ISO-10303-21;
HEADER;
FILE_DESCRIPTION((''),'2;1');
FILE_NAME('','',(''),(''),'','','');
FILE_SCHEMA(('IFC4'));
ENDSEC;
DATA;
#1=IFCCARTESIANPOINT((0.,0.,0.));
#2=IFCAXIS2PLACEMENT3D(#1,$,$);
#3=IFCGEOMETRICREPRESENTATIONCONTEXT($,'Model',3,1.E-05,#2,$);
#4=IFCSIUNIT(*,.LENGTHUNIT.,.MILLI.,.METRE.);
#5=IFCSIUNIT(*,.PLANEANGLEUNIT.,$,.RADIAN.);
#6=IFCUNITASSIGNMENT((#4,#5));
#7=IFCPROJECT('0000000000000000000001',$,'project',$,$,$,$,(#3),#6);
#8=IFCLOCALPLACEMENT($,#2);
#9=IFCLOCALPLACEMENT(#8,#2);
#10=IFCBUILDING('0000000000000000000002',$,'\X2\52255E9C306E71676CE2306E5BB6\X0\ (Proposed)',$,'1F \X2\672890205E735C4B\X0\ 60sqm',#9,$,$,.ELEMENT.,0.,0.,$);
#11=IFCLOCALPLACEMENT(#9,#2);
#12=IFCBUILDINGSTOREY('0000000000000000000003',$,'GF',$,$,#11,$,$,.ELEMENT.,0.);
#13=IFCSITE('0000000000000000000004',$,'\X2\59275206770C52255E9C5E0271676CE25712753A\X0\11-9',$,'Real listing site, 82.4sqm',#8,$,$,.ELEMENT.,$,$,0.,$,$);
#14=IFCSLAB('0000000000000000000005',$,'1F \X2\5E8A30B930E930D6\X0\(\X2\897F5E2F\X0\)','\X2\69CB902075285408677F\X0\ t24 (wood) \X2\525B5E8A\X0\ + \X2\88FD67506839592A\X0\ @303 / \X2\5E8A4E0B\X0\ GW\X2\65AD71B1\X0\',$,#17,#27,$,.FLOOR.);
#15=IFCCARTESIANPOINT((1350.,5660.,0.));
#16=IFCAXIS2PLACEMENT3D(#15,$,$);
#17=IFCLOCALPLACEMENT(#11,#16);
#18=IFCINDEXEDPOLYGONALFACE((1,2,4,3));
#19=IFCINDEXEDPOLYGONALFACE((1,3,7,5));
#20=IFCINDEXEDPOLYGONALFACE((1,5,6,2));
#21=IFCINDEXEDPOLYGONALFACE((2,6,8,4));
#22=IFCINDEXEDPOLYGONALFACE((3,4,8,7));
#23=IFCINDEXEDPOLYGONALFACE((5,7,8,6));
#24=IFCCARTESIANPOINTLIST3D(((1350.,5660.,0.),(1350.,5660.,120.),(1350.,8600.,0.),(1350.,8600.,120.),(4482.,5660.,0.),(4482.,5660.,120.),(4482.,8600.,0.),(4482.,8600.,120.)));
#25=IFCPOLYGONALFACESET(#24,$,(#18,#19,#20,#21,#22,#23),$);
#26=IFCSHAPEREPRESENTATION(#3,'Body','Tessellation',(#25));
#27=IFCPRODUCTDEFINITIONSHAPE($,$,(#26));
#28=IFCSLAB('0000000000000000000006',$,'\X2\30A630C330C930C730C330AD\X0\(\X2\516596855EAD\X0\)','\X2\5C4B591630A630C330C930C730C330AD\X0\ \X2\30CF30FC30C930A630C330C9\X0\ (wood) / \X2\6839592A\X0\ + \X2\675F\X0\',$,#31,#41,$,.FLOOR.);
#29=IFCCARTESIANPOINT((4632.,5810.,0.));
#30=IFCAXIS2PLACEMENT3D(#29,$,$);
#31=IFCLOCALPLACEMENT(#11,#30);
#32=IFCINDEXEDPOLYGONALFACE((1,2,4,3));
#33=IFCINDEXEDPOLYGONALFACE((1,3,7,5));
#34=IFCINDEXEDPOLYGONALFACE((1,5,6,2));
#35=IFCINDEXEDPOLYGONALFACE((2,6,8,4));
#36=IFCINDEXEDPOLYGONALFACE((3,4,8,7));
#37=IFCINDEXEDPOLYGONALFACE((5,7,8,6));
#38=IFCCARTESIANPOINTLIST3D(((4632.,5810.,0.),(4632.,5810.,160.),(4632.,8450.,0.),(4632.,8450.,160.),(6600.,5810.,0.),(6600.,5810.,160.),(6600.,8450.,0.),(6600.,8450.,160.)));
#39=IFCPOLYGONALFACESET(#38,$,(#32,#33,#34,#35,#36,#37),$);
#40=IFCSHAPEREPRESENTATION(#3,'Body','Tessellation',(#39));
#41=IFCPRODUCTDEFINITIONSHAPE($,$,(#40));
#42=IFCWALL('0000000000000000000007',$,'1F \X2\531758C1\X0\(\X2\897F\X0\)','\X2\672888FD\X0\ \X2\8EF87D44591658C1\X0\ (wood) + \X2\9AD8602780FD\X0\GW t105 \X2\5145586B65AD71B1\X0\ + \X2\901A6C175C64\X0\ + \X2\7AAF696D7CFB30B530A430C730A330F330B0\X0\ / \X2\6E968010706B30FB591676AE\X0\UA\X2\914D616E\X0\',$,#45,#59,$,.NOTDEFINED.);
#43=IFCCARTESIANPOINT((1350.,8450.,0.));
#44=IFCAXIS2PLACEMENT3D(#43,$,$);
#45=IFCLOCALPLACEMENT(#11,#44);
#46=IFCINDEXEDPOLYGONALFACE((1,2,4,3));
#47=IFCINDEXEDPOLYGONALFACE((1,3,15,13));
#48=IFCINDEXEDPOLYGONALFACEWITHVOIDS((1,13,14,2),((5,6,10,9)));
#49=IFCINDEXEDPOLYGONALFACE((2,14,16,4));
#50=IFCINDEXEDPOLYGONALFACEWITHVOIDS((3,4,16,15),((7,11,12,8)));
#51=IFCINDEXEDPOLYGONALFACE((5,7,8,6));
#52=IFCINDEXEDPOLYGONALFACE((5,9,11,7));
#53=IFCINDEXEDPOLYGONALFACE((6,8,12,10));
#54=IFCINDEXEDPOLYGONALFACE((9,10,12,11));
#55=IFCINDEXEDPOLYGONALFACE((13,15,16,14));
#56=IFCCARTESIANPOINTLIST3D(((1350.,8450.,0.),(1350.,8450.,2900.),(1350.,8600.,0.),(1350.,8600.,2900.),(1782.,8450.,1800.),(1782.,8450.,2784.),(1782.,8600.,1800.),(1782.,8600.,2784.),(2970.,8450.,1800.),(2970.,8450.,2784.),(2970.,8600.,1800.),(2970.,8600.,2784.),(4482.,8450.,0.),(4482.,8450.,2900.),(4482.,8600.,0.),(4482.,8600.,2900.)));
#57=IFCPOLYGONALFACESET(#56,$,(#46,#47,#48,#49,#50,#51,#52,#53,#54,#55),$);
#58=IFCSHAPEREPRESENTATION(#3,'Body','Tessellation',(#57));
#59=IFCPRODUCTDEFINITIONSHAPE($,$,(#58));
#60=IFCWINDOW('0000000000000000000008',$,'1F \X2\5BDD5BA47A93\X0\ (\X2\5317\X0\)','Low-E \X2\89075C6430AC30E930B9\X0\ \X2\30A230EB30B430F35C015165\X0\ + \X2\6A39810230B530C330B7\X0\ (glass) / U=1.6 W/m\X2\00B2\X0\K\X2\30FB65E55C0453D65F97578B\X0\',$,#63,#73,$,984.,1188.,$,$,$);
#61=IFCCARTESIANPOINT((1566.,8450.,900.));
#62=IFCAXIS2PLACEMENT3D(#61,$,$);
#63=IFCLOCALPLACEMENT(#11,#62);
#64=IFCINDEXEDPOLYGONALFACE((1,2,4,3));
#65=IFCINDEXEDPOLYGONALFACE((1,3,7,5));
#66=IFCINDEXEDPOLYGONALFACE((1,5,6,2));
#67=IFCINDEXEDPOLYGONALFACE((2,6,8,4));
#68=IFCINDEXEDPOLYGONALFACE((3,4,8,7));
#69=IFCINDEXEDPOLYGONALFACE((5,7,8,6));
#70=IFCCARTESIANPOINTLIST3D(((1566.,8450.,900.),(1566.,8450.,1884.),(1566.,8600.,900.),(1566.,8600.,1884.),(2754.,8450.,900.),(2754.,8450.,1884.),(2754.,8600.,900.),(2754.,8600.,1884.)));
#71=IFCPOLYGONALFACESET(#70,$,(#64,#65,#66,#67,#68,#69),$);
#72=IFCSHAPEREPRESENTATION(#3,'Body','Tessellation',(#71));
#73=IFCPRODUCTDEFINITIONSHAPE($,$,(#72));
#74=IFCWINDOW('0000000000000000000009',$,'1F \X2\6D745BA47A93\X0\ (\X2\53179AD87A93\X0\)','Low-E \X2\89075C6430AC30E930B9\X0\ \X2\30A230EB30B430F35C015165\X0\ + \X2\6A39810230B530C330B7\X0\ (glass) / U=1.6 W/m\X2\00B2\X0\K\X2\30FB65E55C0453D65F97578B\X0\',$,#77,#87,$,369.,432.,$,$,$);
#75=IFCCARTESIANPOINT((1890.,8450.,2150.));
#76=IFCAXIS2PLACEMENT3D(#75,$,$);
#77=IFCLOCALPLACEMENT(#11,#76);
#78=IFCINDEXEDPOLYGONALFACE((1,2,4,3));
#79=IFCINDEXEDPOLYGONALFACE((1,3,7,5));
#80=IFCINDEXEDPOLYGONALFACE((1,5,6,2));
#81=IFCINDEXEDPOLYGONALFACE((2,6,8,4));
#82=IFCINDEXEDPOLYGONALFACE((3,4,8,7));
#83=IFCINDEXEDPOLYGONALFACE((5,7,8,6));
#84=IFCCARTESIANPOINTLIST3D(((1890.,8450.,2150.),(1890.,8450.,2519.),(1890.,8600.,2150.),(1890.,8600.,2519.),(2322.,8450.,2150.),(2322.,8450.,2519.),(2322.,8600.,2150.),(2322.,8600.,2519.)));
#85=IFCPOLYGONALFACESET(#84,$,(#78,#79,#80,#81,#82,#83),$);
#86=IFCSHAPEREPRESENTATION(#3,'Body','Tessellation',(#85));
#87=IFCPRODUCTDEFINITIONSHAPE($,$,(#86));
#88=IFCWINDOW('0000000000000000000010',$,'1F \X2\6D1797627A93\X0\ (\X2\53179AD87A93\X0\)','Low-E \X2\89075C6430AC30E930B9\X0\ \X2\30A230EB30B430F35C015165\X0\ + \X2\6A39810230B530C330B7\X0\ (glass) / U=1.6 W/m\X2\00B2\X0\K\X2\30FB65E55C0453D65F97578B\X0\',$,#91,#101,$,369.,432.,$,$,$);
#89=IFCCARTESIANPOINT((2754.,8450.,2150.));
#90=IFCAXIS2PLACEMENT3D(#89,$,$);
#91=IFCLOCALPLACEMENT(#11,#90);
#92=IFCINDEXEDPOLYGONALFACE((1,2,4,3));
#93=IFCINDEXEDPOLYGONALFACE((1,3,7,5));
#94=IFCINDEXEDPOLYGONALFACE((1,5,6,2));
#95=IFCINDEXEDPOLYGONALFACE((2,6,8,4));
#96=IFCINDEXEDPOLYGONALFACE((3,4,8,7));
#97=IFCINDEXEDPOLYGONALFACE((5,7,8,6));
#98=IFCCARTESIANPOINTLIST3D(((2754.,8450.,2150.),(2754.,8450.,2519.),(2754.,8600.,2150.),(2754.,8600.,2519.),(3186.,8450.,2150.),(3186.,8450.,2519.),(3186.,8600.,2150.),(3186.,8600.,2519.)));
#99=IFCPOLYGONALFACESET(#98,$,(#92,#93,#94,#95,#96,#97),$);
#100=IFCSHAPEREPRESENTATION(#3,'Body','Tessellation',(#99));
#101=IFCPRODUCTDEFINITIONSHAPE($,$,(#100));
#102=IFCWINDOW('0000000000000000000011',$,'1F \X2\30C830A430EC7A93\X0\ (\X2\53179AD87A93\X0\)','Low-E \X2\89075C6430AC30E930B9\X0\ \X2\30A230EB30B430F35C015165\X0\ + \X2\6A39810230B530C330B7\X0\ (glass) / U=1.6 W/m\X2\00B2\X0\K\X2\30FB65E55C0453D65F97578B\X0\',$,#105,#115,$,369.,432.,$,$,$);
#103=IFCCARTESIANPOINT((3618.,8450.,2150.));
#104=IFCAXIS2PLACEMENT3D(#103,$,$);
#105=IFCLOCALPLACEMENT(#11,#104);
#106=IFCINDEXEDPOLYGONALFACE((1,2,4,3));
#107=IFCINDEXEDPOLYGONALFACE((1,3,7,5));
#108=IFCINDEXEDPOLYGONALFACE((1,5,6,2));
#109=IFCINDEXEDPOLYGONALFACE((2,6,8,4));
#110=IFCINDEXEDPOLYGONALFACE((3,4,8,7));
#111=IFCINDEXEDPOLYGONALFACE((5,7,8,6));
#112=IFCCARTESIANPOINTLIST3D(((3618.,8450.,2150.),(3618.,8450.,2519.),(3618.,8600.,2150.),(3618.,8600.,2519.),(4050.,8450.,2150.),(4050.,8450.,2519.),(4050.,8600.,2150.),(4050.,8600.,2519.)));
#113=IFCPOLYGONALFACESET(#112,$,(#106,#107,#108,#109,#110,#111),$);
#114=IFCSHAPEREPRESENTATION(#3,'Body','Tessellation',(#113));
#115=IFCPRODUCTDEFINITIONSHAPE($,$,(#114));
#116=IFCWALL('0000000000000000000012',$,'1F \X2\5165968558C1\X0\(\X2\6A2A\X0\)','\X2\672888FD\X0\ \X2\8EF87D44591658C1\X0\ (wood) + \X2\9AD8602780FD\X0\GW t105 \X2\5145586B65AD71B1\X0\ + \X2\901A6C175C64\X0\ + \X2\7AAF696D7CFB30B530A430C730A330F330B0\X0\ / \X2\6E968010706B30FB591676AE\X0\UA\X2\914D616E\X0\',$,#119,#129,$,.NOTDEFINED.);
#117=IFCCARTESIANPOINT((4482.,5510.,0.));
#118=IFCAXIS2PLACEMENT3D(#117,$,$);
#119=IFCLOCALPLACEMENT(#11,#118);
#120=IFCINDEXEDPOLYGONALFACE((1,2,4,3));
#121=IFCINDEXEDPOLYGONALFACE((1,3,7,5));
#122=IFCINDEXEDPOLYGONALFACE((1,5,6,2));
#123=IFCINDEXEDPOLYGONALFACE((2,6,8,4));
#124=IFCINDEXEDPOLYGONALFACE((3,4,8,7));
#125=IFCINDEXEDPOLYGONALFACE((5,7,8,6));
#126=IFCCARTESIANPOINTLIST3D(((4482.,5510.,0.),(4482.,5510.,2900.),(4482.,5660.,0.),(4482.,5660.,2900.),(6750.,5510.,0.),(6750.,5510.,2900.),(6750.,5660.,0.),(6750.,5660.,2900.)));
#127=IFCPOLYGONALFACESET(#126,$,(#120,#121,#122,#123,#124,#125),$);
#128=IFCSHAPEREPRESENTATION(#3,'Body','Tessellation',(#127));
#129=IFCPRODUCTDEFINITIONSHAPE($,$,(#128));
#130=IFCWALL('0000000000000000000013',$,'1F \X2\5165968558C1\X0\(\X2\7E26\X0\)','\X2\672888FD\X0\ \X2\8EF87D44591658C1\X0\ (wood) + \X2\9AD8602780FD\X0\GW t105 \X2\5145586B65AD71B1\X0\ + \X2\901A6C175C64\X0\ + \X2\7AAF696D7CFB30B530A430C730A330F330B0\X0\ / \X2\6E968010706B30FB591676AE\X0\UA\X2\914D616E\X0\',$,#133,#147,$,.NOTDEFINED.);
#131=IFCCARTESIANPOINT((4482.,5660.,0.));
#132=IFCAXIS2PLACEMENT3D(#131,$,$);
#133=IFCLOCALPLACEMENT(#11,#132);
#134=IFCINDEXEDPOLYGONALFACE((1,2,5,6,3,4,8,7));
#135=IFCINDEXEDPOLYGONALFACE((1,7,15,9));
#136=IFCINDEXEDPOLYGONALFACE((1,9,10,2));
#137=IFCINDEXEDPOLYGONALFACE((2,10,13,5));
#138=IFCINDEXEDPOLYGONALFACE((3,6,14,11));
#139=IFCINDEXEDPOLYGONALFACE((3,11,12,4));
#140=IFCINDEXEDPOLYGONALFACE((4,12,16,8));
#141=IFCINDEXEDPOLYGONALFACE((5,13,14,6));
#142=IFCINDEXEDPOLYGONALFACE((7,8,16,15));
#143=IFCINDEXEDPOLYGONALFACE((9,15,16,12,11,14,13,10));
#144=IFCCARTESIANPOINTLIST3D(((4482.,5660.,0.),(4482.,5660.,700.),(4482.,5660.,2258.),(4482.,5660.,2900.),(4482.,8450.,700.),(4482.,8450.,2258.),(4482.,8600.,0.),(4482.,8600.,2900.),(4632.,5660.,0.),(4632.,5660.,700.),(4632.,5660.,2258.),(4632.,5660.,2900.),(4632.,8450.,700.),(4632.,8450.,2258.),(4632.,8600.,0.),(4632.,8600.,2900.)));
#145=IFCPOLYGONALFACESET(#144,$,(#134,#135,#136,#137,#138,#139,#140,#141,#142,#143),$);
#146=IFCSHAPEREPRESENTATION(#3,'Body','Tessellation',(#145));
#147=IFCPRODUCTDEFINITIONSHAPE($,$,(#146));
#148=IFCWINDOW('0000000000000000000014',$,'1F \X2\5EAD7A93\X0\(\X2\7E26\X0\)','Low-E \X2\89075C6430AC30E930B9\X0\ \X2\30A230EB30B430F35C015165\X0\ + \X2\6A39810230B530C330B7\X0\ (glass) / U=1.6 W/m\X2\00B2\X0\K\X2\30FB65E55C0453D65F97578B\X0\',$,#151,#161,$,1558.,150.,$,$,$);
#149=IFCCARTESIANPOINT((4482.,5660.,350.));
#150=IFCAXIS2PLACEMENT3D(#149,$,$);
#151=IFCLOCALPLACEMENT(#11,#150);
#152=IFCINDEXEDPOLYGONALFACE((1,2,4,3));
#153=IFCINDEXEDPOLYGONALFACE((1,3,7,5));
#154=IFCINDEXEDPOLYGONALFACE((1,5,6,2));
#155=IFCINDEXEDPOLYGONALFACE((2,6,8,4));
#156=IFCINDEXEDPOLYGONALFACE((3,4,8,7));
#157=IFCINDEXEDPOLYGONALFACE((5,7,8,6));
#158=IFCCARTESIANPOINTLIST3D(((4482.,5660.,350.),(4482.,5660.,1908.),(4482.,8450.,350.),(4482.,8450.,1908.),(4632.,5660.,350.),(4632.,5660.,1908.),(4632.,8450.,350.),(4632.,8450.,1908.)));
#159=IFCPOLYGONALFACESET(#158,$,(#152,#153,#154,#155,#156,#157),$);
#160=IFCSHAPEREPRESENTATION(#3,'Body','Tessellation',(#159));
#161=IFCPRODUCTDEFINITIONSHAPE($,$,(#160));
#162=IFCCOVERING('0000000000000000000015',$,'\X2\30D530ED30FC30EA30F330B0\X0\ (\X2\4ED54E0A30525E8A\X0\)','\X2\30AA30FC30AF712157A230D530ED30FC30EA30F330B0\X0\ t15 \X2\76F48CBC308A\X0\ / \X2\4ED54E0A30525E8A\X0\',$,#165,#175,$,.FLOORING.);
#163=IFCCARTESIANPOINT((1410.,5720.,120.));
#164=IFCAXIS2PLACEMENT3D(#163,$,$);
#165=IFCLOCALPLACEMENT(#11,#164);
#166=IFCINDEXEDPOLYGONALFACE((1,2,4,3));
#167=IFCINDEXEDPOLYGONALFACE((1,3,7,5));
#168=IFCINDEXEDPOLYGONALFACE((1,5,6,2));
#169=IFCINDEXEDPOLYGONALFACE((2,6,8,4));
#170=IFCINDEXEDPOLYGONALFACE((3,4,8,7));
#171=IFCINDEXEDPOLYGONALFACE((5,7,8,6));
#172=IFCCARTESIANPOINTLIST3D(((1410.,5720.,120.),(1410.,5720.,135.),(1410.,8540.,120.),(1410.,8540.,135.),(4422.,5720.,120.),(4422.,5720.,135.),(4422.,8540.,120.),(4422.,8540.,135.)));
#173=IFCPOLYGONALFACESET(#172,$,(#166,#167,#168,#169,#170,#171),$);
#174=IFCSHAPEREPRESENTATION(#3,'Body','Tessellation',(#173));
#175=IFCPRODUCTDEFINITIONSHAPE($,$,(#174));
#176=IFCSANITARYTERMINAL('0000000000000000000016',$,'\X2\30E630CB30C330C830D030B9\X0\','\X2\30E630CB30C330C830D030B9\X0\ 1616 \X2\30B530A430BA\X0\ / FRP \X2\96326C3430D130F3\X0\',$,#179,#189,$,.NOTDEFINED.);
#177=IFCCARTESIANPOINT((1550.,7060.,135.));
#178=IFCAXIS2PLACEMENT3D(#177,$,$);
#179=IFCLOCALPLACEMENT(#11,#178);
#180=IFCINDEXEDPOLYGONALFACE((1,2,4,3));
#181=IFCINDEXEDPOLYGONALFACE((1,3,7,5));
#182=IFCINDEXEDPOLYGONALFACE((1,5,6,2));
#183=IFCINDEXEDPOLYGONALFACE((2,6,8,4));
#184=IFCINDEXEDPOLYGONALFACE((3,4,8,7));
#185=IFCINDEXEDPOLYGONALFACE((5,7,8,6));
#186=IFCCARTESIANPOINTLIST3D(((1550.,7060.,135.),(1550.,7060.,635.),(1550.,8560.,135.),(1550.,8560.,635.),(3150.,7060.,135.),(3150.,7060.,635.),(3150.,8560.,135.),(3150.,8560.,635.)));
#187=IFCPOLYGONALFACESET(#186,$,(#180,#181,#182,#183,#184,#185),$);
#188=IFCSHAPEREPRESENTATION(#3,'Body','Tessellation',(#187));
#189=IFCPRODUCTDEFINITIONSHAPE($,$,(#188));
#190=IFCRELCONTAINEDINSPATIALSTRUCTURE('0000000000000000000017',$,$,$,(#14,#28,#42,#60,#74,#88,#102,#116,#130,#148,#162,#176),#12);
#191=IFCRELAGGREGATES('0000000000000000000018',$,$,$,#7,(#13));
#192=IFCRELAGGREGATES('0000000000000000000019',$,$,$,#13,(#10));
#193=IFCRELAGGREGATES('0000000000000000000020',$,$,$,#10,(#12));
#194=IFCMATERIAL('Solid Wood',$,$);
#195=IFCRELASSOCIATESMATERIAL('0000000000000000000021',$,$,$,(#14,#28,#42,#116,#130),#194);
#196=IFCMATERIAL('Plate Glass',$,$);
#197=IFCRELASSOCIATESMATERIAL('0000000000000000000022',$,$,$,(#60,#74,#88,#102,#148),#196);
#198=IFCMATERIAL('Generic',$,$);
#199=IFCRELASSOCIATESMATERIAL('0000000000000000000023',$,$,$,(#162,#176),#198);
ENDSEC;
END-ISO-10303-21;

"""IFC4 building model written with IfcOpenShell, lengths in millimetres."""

from ifc_helpers import new_model, si_unit, frame, frame_2d, origin, place, context, project, spatial, rectangle, extrude, material, element, fill, save


model = new_model("IFC4")

# Units and contexts
model_context = context("Model", 3, precision=1e-05, world=origin())
ifc_project = project(units=[si_unit("LENGTHUNIT", "METRE", prefix="MILLI"), si_unit("PLANEANGLEUNIT", "RADIAN")], contexts=[model_context])

# Site, building, storey
site_placement = place(None, origin())
site = spatial("IfcSite", under=ifc_project, at=site_placement, Name="大分県別府市照波園町11-9", ObjectType="Real listing site, 82.4sqm", CompositionType="ELEMENT", RefElevation=0.0)
building_placement = place(site_placement, origin())
building = spatial("IfcBuilding", under=site, at=building_placement, Name="別府の照波の家 (Proposed)", ObjectType="1F 木造平屋 60sqm", CompositionType="ELEMENT", ElevationOfRefHeight=0.0, ElevationOfTerrain=0.0)
storey_placement = place(building_placement, origin())
storey = spatial("IfcBuildingStorey", under=building, at=storey_placement, Name="GF", CompositionType="ELEMENT", Elevation=0.0)

# Slabs
ifc_material_1 = material(Name="Solid Wood")
slab_1_placement = place(storey_placement, frame((1350.0, 5660.0, 0.0)))
element("IfcSlab", 1, at=slab_1_placement, inside=storey, material=ifc_material_1, Name="1F 床スラブ(西帯)", Description="構造用合板 t24 (wood) 剛床 + 製材根太 @303 / 床下 GW断熱", PredefinedType="FLOOR", context=model_context, shape_type="SweptSolid", body=[
    extrude(rectangle(XDim=3132.0, YDim=2940.0, at=frame_2d((1566.0, 1470.0))), frame((1350.0, 5660.0, 0.0)), (0.0, 0.0, 1.0), 120.0),
])
slab_2_placement = place(storey_placement, frame((4632.0, 5810.0, 0.0)))
element("IfcSlab", 2, at=slab_2_placement, inside=storey, material=ifc_material_1, Name="ウッドデッキ(入隅庭)", Description="屋外ウッドデッキ ハードウッド (wood) / 根太 + 束", PredefinedType="FLOOR", context=model_context, shape_type="SweptSolid", body=[
    extrude(rectangle(XDim=1968.0, YDim=2640.0, at=frame_2d((984.0, 1320.0))), frame((4632.0, 5810.0, 0.0)), (0.0, 0.0, 1.0), 160.0),
])

# Wall, openings, windows
wall_1_placement = place(storey_placement, frame((1350.0, 8450.0, 0.0)))
wall_1 = element("IfcWall", 3, at=wall_1_placement, inside=storey, material=ifc_material_1, Name="1F 北壁(西)", Description="木製 軸組外壁 (wood) + 高性能GW t105 充填断熱 + 通気層 + 窯業系サイディング / 準耐火・外皮UA配慮", PredefinedType="NOTDEFINED", context=model_context, shape_type="SweptSolid", body=[
    extrude(rectangle(XDim=3132.0, YDim=150.0, at=frame_2d((1566.0, 75.0))), frame((1350.0, 8450.0, 0.0)), (0.0, 0.0, 1.0), 2900.0),
])
opening_1_placement = place(storey_placement, frame((1566.0, 8450.0, 900.0)))
opening_1 = element("IfcOpeningElement", 4, at=opening_1_placement, cuts=wall_1, PredefinedType="NOTDEFINED", context=model_context, shape_type="SweptSolid", body=[
    extrude(rectangle(XDim=1188.0, YDim=150.0, at=frame_2d((594.0, 75.0))), frame((1566.0, 8450.0, 900.0)), (0.0, 0.0, 1.0), 984.0),
])
opening_2_placement = place(storey_placement, frame((1890.0, 8450.0, 2150.0)))
opening_2 = element("IfcOpeningElement", 5, at=opening_2_placement, cuts=wall_1, PredefinedType="NOTDEFINED", context=model_context, shape_type="SweptSolid", body=[
    extrude(rectangle(XDim=432.0, YDim=150.0, at=frame_2d((216.0, 75.0))), frame((1890.0, 8450.0, 2150.0)), (0.0, 0.0, 1.0), 369.0),
])
opening_3_placement = place(storey_placement, frame((2754.0, 8450.0, 2150.0)))
opening_3 = element("IfcOpeningElement", 6, at=opening_3_placement, cuts=wall_1, PredefinedType="NOTDEFINED", context=model_context, shape_type="SweptSolid", body=[
    extrude(rectangle(XDim=432.0, YDim=150.0, at=frame_2d((216.0, 75.0))), frame((2754.0, 8450.0, 2150.0)), (0.0, 0.0, 1.0), 369.0),
])
opening_4_placement = place(storey_placement, frame((3618.0, 8450.0, 2150.0)))
opening_4 = element("IfcOpeningElement", 7, at=opening_4_placement, cuts=wall_1, PredefinedType="NOTDEFINED", context=model_context, shape_type="SweptSolid", body=[
    extrude(rectangle(XDim=432.0, YDim=150.0, at=frame_2d((216.0, 75.0))), frame((3618.0, 8450.0, 2150.0)), (0.0, 0.0, 1.0), 369.0),
])
ifc_material_2 = material(Name="Plate Glass")
window_1_placement = place(storey_placement, frame((1566.0, 8450.0, 900.0)))
window_1 = element("IfcWindow", 8, at=window_1_placement, inside=storey, material=ifc_material_2, Name="1F 寝室窓 (北)", Description="Low-E 複層ガラス アルゴン封入 + 樹脂サッシ (glass) / U=1.6 W/m²K・日射取得型", OverallHeight=984.0, OverallWidth=1188.0, context=model_context, shape_type="SweptSolid", body=[
    extrude(rectangle(XDim=1188.0, YDim=150.0, at=frame_2d((594.0, 75.0))), frame((1566.0, 8450.0, 900.0)), (0.0, 0.0, 1.0), 984.0),
])
fill(opening_1, window_1)
window_2_placement = place(storey_placement, frame((1890.0, 8450.0, 2150.0)))
window_2 = element("IfcWindow", 9, at=window_2_placement, inside=storey, material=ifc_material_2, Name="1F 浴室窓 (北高窓)", Description="Low-E 複層ガラス アルゴン封入 + 樹脂サッシ (glass) / U=1.6 W/m²K・日射取得型", OverallHeight=369.0, OverallWidth=432.0, context=model_context, shape_type="SweptSolid", body=[
    extrude(rectangle(XDim=432.0, YDim=150.0, at=frame_2d((216.0, 75.0))), frame((1890.0, 8450.0, 2150.0)), (0.0, 0.0, 1.0), 369.0),
])
fill(opening_2, window_2)
window_3_placement = place(storey_placement, frame((2754.0, 8450.0, 2150.0)))
window_3 = element("IfcWindow", 10, at=window_3_placement, inside=storey, material=ifc_material_2, Name="1F 洗面窓 (北高窓)", Description="Low-E 複層ガラス アルゴン封入 + 樹脂サッシ (glass) / U=1.6 W/m²K・日射取得型", OverallHeight=369.0, OverallWidth=432.0, context=model_context, shape_type="SweptSolid", body=[
    extrude(rectangle(XDim=432.0, YDim=150.0, at=frame_2d((216.0, 75.0))), frame((2754.0, 8450.0, 2150.0)), (0.0, 0.0, 1.0), 369.0),
])
fill(opening_3, window_3)
window_4_placement = place(storey_placement, frame((3618.0, 8450.0, 2150.0)))
window_4 = element("IfcWindow", 11, at=window_4_placement, inside=storey, material=ifc_material_2, Name="1F トイレ窓 (北高窓)", Description="Low-E 複層ガラス アルゴン封入 + 樹脂サッシ (glass) / U=1.6 W/m²K・日射取得型", OverallHeight=369.0, OverallWidth=432.0, context=model_context, shape_type="SweptSolid", body=[
    extrude(rectangle(XDim=432.0, YDim=150.0, at=frame_2d((216.0, 75.0))), frame((3618.0, 8450.0, 2150.0)), (0.0, 0.0, 1.0), 369.0),
])
fill(opening_4, window_4)

# Wall
wall_2_placement = place(storey_placement, frame((4482.0, 5510.0, 0.0)))
element("IfcWall", 12, at=wall_2_placement, inside=storey, material=ifc_material_1, Name="1F 入隅壁(横)", Description="木製 軸組外壁 (wood) + 高性能GW t105 充填断熱 + 通気層 + 窯業系サイディング / 準耐火・外皮UA配慮", PredefinedType="NOTDEFINED", context=model_context, shape_type="SweptSolid", body=[
    extrude(rectangle(XDim=2268.0, YDim=150.0, at=frame_2d((1134.0, 75.0))), frame((4482.0, 5510.0, 0.0)), (0.0, 0.0, 1.0), 2900.0),
])

# Wall, opening, window
wall_3_placement = place(storey_placement, frame((4482.0, 5660.0, 0.0)))
wall_3 = element("IfcWall", 13, at=wall_3_placement, inside=storey, material=ifc_material_1, Name="1F 入隅壁(縦)", Description="木製 軸組外壁 (wood) + 高性能GW t105 充填断熱 + 通気層 + 窯業系サイディング / 準耐火・外皮UA配慮", PredefinedType="NOTDEFINED", context=model_context, shape_type="SweptSolid", body=[
    extrude(rectangle(XDim=150.0, YDim=2940.0, at=frame_2d((75.0, 1470.0))), frame((4482.0, 5660.0, 0.0)), (0.0, 0.0, 1.0), 2900.0),
])
opening_5_placement = place(storey_placement, frame((4482.0, 5660.0, 350.0)))
opening_5 = element("IfcOpeningElement", 14, at=opening_5_placement, cuts=wall_3, PredefinedType="NOTDEFINED", context=model_context, shape_type="SweptSolid", body=[
    extrude(rectangle(XDim=150.0, YDim=2790.0, at=frame_2d((75.0, 1395.0))), frame((4482.0, 5660.0, 350.0)), (0.0, 0.0, 1.0), 1558.0),
])
window_5_placement = place(storey_placement, frame((4482.0, 5660.0, 350.0)))
window_5 = element("IfcWindow", 15, at=window_5_placement, inside=storey, material=ifc_material_2, Name="1F 庭窓(縦)", Description="Low-E 複層ガラス アルゴン封入 + 樹脂サッシ (glass) / U=1.6 W/m²K・日射取得型", OverallHeight=1558.0, OverallWidth=150.0, context=model_context, shape_type="SweptSolid", body=[
    extrude(rectangle(XDim=150.0, YDim=2790.0, at=frame_2d((75.0, 1395.0))), frame((4482.0, 5660.0, 350.0)), (0.0, 0.0, 1.0), 1558.0),
])
fill(opening_5, window_5)

# Covering
ifc_material_3 = material(Name="Generic")
covering_placement = place(storey_placement, frame((1410.0, 5720.0, 120.0)))
element("IfcCovering", 16, at=covering_placement, inside=storey, material=ifc_material_3, Name="フローリング (仕上げ床)", Description="オーク無垢フローリング t15 直貼り / 仕上げ床", PredefinedType="FLOORING", context=model_context, shape_type="SweptSolid", body=[
    extrude(rectangle(XDim=3012.0, YDim=2820.0, at=frame_2d((1506.0, 1410.0))), frame((1410.0, 5720.0, 120.0)), (0.0, 0.0, 1.0), 15.0),
])

# Sanitary terminal
sanitary_terminal_1_placement = place(storey_placement, frame((1550.0, 7060.0, 135.0)))
element("IfcSanitaryTerminal", 17, at=sanitary_terminal_1_placement, inside=storey, material=ifc_material_3, Name="ユニットバス", Description="ユニットバス 1616 サイズ / FRP 防水パン", PredefinedType="NOTDEFINED", context=model_context, shape_type="SweptSolid", body=[
    extrude(rectangle(XDim=1600.0, YDim=1500.0, at=frame_2d((800.0, 750.0))), frame((1550.0, 7060.0, 135.0)), (0.0, 0.0, 1.0), 500.0),
])

save(model, "model.ifc")
